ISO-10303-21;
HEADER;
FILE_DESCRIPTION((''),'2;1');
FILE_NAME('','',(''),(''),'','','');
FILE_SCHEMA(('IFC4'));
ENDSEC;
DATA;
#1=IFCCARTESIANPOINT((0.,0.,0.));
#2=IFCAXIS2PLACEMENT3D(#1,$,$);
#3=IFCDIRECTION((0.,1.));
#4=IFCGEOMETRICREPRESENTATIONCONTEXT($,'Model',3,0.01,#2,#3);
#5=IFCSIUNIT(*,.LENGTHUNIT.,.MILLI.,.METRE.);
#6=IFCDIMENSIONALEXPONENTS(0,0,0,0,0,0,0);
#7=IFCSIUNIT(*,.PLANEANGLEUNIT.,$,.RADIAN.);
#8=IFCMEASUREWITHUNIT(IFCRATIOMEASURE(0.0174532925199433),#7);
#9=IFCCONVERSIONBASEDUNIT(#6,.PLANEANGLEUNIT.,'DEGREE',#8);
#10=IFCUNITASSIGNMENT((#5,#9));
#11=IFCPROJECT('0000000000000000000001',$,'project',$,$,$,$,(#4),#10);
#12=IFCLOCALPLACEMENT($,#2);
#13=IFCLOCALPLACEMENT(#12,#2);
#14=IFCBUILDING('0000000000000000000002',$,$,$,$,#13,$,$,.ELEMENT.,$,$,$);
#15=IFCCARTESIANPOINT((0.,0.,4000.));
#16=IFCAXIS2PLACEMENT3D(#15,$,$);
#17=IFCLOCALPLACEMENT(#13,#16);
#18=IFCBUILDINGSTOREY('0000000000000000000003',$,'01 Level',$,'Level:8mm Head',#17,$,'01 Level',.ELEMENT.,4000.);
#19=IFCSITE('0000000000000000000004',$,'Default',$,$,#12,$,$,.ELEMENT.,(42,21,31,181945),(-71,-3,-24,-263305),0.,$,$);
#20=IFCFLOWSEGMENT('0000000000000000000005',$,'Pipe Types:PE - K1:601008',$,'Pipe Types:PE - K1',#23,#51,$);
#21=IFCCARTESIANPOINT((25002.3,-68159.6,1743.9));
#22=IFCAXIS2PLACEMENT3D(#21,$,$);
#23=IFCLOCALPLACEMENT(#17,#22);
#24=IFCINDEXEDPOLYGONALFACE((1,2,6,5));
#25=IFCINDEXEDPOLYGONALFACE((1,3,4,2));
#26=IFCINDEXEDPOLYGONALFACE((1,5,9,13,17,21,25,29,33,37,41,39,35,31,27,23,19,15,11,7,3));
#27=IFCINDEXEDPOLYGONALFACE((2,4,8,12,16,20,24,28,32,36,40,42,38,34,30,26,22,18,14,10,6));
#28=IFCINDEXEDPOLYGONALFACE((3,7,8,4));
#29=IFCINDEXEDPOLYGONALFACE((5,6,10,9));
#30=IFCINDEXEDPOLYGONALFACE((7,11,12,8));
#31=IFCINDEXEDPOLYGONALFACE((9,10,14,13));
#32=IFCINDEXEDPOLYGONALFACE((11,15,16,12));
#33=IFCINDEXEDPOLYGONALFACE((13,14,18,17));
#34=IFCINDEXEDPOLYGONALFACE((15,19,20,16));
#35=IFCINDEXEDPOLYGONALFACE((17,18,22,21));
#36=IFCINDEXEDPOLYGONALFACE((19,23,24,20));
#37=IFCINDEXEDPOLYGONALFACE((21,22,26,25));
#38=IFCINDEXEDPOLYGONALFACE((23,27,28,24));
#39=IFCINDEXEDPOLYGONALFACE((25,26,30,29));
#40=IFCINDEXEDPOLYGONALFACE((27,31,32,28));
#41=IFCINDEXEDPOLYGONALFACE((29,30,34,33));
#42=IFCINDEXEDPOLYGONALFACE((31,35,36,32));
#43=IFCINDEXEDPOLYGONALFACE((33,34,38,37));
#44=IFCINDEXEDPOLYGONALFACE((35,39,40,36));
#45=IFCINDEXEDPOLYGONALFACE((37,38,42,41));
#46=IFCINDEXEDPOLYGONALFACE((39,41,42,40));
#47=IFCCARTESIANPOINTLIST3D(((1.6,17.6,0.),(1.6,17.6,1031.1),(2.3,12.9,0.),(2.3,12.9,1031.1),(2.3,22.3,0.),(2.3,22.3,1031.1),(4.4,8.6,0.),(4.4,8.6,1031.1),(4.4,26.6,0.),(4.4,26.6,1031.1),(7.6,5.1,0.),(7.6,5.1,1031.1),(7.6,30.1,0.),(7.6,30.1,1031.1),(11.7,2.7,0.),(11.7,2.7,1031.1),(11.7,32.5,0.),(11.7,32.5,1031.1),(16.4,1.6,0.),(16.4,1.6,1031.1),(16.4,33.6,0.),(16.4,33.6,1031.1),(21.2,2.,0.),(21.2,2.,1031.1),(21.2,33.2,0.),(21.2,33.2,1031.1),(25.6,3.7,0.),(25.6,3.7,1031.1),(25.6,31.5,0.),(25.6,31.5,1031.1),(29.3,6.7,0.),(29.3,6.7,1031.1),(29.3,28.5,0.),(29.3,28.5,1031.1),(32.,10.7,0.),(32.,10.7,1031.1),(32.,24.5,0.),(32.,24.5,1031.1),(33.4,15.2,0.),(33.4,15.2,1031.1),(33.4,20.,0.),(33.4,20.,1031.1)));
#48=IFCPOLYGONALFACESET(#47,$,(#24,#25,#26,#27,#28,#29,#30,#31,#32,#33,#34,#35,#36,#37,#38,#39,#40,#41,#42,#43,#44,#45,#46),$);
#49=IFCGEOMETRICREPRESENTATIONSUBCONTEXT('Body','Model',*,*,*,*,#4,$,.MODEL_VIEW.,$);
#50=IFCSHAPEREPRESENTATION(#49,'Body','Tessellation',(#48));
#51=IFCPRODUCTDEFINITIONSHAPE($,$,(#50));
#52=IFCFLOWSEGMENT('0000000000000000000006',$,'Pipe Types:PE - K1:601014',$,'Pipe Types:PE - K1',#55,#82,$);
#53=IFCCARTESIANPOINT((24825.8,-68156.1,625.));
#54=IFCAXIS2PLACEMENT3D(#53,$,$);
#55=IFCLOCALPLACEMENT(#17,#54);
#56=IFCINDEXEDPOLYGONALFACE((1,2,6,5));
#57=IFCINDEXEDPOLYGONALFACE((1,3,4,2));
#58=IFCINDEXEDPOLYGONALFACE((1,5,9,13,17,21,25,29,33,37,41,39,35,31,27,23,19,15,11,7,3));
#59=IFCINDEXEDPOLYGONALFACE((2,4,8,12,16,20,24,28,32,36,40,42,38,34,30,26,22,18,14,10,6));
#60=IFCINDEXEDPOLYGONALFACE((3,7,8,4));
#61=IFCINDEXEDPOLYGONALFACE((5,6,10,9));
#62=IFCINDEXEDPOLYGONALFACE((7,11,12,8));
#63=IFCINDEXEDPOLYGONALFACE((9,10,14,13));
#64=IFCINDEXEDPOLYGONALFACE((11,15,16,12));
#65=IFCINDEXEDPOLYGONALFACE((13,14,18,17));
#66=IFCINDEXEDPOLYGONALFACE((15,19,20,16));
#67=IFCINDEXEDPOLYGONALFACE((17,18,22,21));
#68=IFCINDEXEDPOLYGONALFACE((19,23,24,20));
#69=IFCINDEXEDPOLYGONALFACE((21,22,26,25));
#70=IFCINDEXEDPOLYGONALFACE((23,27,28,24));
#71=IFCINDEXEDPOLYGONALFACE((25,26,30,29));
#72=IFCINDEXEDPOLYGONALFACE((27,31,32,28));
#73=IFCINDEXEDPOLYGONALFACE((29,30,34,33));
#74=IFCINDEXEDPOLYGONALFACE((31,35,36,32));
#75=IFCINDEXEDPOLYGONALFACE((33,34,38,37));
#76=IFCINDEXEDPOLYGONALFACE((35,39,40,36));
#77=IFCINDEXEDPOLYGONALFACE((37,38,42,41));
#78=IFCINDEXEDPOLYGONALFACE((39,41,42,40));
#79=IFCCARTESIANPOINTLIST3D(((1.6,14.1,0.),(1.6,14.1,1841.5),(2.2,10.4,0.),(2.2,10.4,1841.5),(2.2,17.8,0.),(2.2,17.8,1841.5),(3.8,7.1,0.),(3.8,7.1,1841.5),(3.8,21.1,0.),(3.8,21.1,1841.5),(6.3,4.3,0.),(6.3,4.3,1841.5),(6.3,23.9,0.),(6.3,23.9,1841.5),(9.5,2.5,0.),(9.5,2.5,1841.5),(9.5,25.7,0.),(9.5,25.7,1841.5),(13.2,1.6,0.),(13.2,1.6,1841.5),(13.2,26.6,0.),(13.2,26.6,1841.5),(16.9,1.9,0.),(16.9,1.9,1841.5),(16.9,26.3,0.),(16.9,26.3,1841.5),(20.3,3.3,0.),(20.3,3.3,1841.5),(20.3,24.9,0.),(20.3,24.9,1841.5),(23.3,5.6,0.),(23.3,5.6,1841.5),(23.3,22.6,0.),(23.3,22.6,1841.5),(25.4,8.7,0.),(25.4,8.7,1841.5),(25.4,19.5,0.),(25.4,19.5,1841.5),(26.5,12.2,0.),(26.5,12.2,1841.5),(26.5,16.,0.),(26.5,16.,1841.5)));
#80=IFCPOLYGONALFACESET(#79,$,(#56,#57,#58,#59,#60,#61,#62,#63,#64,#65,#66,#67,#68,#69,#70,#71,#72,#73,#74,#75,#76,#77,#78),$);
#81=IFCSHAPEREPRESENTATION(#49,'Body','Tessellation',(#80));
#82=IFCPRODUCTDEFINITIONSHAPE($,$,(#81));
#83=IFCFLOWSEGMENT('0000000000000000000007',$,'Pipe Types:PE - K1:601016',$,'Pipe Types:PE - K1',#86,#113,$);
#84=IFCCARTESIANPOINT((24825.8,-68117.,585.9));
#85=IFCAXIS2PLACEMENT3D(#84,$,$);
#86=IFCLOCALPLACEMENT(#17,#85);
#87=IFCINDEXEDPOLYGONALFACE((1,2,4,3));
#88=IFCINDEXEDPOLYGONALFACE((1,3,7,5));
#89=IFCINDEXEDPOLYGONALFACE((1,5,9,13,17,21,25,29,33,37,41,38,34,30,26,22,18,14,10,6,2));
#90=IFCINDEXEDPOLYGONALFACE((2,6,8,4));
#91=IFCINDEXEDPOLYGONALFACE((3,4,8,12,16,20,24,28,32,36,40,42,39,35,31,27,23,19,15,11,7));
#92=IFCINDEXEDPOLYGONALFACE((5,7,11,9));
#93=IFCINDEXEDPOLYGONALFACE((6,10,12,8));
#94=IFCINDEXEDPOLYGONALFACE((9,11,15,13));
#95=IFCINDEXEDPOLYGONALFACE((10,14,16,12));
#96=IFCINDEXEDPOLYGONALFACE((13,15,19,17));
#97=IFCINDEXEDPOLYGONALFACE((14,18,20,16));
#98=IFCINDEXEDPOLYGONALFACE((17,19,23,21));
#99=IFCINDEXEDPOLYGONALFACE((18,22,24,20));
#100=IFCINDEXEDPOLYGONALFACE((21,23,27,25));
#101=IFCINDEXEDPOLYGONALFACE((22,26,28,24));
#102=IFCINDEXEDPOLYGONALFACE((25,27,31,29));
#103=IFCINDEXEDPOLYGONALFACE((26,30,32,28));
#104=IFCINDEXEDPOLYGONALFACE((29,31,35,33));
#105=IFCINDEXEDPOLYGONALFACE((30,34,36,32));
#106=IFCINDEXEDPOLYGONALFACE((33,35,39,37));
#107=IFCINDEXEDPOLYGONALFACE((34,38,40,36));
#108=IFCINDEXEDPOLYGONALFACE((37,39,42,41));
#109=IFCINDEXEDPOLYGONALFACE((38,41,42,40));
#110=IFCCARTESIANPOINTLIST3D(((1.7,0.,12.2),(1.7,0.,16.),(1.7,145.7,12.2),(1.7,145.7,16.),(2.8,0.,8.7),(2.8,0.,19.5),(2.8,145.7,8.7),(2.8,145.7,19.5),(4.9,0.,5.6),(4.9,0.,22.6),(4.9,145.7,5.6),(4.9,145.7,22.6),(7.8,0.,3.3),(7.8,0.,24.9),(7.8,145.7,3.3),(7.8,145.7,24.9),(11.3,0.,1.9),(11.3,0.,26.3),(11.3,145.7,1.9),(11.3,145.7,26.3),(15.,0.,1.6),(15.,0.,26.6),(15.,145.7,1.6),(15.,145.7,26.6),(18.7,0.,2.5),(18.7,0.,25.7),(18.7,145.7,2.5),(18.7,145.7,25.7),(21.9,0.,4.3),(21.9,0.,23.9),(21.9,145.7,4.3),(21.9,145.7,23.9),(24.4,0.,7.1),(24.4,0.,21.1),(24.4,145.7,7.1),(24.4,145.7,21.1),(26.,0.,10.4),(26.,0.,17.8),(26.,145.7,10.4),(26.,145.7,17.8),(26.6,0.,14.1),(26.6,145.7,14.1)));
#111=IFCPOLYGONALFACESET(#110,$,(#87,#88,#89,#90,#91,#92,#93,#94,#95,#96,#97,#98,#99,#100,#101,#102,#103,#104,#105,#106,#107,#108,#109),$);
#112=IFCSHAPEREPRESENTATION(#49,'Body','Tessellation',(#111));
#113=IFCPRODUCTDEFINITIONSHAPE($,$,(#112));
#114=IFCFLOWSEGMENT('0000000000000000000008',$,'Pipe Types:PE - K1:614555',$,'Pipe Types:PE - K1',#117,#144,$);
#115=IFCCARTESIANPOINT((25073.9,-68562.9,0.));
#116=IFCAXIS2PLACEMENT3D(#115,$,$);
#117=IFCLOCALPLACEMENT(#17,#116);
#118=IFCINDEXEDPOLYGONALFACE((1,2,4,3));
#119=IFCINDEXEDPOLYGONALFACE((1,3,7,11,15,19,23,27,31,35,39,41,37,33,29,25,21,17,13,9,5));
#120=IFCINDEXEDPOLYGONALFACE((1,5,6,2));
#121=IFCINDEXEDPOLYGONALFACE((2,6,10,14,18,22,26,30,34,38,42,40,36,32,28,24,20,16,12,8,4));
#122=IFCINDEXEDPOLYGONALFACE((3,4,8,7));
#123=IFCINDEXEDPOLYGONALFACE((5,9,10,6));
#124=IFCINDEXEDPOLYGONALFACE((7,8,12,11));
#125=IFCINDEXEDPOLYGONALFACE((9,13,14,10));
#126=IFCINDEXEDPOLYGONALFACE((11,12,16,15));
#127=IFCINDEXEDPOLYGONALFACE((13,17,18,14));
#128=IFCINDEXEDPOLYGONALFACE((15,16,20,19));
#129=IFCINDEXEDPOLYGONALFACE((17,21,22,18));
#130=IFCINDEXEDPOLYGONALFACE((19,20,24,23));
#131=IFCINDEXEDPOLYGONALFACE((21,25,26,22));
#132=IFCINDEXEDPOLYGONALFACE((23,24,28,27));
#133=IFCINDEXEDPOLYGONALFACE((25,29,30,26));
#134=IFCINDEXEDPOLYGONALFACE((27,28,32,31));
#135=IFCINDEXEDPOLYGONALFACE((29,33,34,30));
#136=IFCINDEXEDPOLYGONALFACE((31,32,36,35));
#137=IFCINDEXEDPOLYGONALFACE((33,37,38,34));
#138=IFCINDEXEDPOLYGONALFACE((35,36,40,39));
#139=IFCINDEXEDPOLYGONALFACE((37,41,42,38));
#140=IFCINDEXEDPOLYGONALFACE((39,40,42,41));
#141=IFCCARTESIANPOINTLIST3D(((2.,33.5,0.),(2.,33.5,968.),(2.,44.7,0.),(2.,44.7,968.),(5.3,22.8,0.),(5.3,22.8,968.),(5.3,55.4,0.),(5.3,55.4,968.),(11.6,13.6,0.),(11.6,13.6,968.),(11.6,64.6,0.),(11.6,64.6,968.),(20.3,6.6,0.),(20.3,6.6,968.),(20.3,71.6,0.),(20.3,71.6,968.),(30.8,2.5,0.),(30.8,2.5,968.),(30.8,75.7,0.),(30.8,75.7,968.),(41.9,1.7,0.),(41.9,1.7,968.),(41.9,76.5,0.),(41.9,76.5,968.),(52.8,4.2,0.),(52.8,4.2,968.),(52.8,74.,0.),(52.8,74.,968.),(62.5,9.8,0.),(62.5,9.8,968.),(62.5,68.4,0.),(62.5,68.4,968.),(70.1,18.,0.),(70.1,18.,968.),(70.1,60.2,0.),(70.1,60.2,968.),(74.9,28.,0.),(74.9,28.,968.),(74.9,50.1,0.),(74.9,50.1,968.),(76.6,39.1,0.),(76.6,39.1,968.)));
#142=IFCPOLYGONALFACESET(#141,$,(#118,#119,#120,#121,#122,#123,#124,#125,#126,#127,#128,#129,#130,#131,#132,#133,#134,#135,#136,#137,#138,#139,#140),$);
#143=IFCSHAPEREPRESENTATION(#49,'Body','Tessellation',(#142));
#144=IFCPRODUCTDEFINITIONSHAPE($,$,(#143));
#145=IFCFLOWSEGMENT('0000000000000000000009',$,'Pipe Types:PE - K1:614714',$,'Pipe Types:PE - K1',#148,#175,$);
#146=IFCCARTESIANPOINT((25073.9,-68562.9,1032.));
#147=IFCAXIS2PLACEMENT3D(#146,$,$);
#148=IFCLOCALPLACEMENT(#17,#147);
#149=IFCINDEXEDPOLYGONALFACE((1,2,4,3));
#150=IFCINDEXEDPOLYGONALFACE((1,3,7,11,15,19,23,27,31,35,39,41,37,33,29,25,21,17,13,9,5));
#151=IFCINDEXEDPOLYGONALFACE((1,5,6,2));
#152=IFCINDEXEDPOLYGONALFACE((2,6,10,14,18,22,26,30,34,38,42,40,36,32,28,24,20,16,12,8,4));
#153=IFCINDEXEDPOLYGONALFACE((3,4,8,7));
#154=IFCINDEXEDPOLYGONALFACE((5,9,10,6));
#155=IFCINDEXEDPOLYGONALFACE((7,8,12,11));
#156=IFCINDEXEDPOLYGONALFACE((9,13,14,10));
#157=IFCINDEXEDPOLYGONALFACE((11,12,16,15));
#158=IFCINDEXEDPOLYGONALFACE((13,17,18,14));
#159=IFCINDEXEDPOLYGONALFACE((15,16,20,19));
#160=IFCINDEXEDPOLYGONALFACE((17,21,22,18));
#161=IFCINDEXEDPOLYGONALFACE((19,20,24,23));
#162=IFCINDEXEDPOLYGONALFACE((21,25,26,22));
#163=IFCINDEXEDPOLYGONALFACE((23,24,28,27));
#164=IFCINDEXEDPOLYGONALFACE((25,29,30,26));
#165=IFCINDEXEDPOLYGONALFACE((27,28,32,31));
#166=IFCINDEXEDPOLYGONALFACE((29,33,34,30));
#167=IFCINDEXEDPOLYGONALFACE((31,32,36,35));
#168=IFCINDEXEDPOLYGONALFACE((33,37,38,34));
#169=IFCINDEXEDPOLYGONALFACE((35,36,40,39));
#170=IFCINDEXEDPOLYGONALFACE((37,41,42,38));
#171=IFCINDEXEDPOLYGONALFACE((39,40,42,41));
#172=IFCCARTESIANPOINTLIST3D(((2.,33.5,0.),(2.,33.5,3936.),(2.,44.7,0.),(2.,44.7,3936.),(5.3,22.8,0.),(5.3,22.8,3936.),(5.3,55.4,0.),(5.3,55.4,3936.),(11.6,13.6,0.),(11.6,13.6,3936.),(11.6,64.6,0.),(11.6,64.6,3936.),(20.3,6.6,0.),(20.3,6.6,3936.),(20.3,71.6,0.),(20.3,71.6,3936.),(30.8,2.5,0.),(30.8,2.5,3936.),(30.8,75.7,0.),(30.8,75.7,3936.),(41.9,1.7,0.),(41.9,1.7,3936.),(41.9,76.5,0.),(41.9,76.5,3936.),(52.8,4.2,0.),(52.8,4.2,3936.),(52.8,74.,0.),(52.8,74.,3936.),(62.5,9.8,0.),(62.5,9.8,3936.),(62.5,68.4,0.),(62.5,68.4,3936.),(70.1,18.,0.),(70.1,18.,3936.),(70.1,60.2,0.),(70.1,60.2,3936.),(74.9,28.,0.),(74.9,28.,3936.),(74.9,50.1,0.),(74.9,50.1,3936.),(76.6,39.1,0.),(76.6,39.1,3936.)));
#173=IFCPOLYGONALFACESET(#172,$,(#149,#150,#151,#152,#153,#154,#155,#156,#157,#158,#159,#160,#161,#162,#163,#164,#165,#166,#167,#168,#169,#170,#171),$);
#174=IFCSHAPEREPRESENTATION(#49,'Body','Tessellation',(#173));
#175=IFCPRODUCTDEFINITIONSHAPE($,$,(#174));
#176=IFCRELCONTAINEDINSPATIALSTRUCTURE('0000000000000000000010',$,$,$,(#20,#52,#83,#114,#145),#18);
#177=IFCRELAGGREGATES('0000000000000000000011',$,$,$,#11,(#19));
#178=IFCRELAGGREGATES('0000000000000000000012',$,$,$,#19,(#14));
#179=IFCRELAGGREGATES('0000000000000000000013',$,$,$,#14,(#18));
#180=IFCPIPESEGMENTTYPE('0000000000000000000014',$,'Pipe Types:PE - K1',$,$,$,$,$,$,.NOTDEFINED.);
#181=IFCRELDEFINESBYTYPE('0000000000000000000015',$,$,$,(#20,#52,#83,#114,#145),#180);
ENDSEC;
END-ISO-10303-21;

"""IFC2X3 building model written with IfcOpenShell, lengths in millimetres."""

from ifc_helpers import new_model, entity, si_unit, converted_unit, direction, frame, origin, origin_2d_with_axis, place, context, subcontext, project, spatial, circle, extrude, type_object, element, save


model = new_model("IFC2X3")

# Units and contexts
model_context = context("Model", 3, precision=0.01, world=origin(), true_north=direction((0.0, 1.0)))
body_context = subcontext(model_context, "Body", "Model", "MODEL_VIEW")
ifc_project = project(units=[si_unit("LENGTHUNIT", "METRE", prefix="MILLI"), converted_unit("PLANEANGLEUNIT", "DEGREE", entity("IfcRatioMeasure", 0.0174532925199433), si_unit("PLANEANGLEUNIT", "RADIAN"), dimensions=[0, 0, 0, 0, 0, 0, 0])], contexts=[model_context])

# Site, building, storey
site_placement = place(None, origin())
site = spatial("IfcSite", under=ifc_project, at=site_placement, Name="Default", CompositionType="ELEMENT", RefLatitude=(42, 21, 31, 181945), RefLongitude=(-71, -3, -24, -263305), RefElevation=0.0)
building_placement = place(site_placement, origin())
building = spatial("IfcBuilding", under=site, at=building_placement, CompositionType="ELEMENT")
storey_placement = place(building_placement, frame((0.0, 0.0, 4000.0)))
storey = spatial("IfcBuildingStorey", under=building, at=storey_placement, Name="01 Level", ObjectType="Level:8mm Head", LongName="01 Level", CompositionType="ELEMENT", Elevation=4000.0)

# Flow segments
pipe_segment_type = type_object("IfcPipeSegmentType", Name="Pipe Types:PE - K1", PredefinedType="NOTDEFINED")
flow_segment_1_placement = place(storey_placement, frame((25002.3, -68159.6, 1743.9)))
element("IfcFlowSegment", 1, at=flow_segment_1_placement, inside=storey, type_object=pipe_segment_type, Name="Pipe Types:PE - K1:601008", ObjectType="Pipe Types:PE - K1", context=body_context, shape_type="SweptSolid", body=[
    extrude(circle(Radius=16.0, at=origin_2d_with_axis()), frame((17.6, 17.6, 0.0), z_axis=(0.0, 0.0, 1.0), x_axis=(-1.0, 0.0, 0.0)), (0.0, 0.0, 1.0), 1031.1),
])
flow_segment_2_placement = place(storey_placement, frame((24825.8, -68156.1, 625.0)))
element("IfcFlowSegment", 2, at=flow_segment_2_placement, inside=storey, type_object=pipe_segment_type, Name="Pipe Types:PE - K1:601014", ObjectType="Pipe Types:PE - K1", context=body_context, shape_type="SweptSolid", body=[
    extrude(circle(Radius=12.5, at=origin_2d_with_axis()), frame((14.1, 14.1, 0.0), z_axis=(0.0, 0.0, 1.0), x_axis=(-1.0, 0.0, 0.0)), (0.0, 0.0, 1.0), 1841.5),
])
flow_segment_3_placement = place(storey_placement, frame((24825.8, -68117.0, 585.9)))
element("IfcFlowSegment", 3, at=flow_segment_3_placement, inside=storey, type_object=pipe_segment_type, Name="Pipe Types:PE - K1:601016", ObjectType="Pipe Types:PE - K1", context=body_context, shape_type="SweptSolid", body=[
    extrude(circle(Radius=12.5, at=origin_2d_with_axis()), frame((14.1, 0.0, 14.1), z_axis=(0.0, 1.0, 0.0), x_axis=(1.0, 0.0, 0.0)), (0.0, 0.0, 1.0), 145.7),
])
flow_segment_4_placement = place(storey_placement, frame((25073.9, -68562.9, 0.0)))
element("IfcFlowSegment", 4, at=flow_segment_4_placement, inside=storey, type_object=pipe_segment_type, Name="Pipe Types:PE - K1:614555", ObjectType="Pipe Types:PE - K1", context=body_context, shape_type="SweptSolid", body=[
    extrude(circle(Radius=37.5, at=origin_2d_with_axis()), frame((39.1, 39.1, 0.0)), (0.0, 0.0, 1.0), 968.0),
])
flow_segment_5_placement = place(storey_placement, frame((25073.9, -68562.9, 1032.0)))
element("IfcFlowSegment", 5, at=flow_segment_5_placement, inside=storey, type_object=pipe_segment_type, Name="Pipe Types:PE - K1:614714", ObjectType="Pipe Types:PE - K1", context=body_context, shape_type="SweptSolid", body=[
    extrude(circle(Radius=37.5, at=origin_2d_with_axis()), frame((39.1, 39.1, 0.0)), (0.0, 0.0, 1.0), 3936.0),
])

save(model, "model.ifc")
